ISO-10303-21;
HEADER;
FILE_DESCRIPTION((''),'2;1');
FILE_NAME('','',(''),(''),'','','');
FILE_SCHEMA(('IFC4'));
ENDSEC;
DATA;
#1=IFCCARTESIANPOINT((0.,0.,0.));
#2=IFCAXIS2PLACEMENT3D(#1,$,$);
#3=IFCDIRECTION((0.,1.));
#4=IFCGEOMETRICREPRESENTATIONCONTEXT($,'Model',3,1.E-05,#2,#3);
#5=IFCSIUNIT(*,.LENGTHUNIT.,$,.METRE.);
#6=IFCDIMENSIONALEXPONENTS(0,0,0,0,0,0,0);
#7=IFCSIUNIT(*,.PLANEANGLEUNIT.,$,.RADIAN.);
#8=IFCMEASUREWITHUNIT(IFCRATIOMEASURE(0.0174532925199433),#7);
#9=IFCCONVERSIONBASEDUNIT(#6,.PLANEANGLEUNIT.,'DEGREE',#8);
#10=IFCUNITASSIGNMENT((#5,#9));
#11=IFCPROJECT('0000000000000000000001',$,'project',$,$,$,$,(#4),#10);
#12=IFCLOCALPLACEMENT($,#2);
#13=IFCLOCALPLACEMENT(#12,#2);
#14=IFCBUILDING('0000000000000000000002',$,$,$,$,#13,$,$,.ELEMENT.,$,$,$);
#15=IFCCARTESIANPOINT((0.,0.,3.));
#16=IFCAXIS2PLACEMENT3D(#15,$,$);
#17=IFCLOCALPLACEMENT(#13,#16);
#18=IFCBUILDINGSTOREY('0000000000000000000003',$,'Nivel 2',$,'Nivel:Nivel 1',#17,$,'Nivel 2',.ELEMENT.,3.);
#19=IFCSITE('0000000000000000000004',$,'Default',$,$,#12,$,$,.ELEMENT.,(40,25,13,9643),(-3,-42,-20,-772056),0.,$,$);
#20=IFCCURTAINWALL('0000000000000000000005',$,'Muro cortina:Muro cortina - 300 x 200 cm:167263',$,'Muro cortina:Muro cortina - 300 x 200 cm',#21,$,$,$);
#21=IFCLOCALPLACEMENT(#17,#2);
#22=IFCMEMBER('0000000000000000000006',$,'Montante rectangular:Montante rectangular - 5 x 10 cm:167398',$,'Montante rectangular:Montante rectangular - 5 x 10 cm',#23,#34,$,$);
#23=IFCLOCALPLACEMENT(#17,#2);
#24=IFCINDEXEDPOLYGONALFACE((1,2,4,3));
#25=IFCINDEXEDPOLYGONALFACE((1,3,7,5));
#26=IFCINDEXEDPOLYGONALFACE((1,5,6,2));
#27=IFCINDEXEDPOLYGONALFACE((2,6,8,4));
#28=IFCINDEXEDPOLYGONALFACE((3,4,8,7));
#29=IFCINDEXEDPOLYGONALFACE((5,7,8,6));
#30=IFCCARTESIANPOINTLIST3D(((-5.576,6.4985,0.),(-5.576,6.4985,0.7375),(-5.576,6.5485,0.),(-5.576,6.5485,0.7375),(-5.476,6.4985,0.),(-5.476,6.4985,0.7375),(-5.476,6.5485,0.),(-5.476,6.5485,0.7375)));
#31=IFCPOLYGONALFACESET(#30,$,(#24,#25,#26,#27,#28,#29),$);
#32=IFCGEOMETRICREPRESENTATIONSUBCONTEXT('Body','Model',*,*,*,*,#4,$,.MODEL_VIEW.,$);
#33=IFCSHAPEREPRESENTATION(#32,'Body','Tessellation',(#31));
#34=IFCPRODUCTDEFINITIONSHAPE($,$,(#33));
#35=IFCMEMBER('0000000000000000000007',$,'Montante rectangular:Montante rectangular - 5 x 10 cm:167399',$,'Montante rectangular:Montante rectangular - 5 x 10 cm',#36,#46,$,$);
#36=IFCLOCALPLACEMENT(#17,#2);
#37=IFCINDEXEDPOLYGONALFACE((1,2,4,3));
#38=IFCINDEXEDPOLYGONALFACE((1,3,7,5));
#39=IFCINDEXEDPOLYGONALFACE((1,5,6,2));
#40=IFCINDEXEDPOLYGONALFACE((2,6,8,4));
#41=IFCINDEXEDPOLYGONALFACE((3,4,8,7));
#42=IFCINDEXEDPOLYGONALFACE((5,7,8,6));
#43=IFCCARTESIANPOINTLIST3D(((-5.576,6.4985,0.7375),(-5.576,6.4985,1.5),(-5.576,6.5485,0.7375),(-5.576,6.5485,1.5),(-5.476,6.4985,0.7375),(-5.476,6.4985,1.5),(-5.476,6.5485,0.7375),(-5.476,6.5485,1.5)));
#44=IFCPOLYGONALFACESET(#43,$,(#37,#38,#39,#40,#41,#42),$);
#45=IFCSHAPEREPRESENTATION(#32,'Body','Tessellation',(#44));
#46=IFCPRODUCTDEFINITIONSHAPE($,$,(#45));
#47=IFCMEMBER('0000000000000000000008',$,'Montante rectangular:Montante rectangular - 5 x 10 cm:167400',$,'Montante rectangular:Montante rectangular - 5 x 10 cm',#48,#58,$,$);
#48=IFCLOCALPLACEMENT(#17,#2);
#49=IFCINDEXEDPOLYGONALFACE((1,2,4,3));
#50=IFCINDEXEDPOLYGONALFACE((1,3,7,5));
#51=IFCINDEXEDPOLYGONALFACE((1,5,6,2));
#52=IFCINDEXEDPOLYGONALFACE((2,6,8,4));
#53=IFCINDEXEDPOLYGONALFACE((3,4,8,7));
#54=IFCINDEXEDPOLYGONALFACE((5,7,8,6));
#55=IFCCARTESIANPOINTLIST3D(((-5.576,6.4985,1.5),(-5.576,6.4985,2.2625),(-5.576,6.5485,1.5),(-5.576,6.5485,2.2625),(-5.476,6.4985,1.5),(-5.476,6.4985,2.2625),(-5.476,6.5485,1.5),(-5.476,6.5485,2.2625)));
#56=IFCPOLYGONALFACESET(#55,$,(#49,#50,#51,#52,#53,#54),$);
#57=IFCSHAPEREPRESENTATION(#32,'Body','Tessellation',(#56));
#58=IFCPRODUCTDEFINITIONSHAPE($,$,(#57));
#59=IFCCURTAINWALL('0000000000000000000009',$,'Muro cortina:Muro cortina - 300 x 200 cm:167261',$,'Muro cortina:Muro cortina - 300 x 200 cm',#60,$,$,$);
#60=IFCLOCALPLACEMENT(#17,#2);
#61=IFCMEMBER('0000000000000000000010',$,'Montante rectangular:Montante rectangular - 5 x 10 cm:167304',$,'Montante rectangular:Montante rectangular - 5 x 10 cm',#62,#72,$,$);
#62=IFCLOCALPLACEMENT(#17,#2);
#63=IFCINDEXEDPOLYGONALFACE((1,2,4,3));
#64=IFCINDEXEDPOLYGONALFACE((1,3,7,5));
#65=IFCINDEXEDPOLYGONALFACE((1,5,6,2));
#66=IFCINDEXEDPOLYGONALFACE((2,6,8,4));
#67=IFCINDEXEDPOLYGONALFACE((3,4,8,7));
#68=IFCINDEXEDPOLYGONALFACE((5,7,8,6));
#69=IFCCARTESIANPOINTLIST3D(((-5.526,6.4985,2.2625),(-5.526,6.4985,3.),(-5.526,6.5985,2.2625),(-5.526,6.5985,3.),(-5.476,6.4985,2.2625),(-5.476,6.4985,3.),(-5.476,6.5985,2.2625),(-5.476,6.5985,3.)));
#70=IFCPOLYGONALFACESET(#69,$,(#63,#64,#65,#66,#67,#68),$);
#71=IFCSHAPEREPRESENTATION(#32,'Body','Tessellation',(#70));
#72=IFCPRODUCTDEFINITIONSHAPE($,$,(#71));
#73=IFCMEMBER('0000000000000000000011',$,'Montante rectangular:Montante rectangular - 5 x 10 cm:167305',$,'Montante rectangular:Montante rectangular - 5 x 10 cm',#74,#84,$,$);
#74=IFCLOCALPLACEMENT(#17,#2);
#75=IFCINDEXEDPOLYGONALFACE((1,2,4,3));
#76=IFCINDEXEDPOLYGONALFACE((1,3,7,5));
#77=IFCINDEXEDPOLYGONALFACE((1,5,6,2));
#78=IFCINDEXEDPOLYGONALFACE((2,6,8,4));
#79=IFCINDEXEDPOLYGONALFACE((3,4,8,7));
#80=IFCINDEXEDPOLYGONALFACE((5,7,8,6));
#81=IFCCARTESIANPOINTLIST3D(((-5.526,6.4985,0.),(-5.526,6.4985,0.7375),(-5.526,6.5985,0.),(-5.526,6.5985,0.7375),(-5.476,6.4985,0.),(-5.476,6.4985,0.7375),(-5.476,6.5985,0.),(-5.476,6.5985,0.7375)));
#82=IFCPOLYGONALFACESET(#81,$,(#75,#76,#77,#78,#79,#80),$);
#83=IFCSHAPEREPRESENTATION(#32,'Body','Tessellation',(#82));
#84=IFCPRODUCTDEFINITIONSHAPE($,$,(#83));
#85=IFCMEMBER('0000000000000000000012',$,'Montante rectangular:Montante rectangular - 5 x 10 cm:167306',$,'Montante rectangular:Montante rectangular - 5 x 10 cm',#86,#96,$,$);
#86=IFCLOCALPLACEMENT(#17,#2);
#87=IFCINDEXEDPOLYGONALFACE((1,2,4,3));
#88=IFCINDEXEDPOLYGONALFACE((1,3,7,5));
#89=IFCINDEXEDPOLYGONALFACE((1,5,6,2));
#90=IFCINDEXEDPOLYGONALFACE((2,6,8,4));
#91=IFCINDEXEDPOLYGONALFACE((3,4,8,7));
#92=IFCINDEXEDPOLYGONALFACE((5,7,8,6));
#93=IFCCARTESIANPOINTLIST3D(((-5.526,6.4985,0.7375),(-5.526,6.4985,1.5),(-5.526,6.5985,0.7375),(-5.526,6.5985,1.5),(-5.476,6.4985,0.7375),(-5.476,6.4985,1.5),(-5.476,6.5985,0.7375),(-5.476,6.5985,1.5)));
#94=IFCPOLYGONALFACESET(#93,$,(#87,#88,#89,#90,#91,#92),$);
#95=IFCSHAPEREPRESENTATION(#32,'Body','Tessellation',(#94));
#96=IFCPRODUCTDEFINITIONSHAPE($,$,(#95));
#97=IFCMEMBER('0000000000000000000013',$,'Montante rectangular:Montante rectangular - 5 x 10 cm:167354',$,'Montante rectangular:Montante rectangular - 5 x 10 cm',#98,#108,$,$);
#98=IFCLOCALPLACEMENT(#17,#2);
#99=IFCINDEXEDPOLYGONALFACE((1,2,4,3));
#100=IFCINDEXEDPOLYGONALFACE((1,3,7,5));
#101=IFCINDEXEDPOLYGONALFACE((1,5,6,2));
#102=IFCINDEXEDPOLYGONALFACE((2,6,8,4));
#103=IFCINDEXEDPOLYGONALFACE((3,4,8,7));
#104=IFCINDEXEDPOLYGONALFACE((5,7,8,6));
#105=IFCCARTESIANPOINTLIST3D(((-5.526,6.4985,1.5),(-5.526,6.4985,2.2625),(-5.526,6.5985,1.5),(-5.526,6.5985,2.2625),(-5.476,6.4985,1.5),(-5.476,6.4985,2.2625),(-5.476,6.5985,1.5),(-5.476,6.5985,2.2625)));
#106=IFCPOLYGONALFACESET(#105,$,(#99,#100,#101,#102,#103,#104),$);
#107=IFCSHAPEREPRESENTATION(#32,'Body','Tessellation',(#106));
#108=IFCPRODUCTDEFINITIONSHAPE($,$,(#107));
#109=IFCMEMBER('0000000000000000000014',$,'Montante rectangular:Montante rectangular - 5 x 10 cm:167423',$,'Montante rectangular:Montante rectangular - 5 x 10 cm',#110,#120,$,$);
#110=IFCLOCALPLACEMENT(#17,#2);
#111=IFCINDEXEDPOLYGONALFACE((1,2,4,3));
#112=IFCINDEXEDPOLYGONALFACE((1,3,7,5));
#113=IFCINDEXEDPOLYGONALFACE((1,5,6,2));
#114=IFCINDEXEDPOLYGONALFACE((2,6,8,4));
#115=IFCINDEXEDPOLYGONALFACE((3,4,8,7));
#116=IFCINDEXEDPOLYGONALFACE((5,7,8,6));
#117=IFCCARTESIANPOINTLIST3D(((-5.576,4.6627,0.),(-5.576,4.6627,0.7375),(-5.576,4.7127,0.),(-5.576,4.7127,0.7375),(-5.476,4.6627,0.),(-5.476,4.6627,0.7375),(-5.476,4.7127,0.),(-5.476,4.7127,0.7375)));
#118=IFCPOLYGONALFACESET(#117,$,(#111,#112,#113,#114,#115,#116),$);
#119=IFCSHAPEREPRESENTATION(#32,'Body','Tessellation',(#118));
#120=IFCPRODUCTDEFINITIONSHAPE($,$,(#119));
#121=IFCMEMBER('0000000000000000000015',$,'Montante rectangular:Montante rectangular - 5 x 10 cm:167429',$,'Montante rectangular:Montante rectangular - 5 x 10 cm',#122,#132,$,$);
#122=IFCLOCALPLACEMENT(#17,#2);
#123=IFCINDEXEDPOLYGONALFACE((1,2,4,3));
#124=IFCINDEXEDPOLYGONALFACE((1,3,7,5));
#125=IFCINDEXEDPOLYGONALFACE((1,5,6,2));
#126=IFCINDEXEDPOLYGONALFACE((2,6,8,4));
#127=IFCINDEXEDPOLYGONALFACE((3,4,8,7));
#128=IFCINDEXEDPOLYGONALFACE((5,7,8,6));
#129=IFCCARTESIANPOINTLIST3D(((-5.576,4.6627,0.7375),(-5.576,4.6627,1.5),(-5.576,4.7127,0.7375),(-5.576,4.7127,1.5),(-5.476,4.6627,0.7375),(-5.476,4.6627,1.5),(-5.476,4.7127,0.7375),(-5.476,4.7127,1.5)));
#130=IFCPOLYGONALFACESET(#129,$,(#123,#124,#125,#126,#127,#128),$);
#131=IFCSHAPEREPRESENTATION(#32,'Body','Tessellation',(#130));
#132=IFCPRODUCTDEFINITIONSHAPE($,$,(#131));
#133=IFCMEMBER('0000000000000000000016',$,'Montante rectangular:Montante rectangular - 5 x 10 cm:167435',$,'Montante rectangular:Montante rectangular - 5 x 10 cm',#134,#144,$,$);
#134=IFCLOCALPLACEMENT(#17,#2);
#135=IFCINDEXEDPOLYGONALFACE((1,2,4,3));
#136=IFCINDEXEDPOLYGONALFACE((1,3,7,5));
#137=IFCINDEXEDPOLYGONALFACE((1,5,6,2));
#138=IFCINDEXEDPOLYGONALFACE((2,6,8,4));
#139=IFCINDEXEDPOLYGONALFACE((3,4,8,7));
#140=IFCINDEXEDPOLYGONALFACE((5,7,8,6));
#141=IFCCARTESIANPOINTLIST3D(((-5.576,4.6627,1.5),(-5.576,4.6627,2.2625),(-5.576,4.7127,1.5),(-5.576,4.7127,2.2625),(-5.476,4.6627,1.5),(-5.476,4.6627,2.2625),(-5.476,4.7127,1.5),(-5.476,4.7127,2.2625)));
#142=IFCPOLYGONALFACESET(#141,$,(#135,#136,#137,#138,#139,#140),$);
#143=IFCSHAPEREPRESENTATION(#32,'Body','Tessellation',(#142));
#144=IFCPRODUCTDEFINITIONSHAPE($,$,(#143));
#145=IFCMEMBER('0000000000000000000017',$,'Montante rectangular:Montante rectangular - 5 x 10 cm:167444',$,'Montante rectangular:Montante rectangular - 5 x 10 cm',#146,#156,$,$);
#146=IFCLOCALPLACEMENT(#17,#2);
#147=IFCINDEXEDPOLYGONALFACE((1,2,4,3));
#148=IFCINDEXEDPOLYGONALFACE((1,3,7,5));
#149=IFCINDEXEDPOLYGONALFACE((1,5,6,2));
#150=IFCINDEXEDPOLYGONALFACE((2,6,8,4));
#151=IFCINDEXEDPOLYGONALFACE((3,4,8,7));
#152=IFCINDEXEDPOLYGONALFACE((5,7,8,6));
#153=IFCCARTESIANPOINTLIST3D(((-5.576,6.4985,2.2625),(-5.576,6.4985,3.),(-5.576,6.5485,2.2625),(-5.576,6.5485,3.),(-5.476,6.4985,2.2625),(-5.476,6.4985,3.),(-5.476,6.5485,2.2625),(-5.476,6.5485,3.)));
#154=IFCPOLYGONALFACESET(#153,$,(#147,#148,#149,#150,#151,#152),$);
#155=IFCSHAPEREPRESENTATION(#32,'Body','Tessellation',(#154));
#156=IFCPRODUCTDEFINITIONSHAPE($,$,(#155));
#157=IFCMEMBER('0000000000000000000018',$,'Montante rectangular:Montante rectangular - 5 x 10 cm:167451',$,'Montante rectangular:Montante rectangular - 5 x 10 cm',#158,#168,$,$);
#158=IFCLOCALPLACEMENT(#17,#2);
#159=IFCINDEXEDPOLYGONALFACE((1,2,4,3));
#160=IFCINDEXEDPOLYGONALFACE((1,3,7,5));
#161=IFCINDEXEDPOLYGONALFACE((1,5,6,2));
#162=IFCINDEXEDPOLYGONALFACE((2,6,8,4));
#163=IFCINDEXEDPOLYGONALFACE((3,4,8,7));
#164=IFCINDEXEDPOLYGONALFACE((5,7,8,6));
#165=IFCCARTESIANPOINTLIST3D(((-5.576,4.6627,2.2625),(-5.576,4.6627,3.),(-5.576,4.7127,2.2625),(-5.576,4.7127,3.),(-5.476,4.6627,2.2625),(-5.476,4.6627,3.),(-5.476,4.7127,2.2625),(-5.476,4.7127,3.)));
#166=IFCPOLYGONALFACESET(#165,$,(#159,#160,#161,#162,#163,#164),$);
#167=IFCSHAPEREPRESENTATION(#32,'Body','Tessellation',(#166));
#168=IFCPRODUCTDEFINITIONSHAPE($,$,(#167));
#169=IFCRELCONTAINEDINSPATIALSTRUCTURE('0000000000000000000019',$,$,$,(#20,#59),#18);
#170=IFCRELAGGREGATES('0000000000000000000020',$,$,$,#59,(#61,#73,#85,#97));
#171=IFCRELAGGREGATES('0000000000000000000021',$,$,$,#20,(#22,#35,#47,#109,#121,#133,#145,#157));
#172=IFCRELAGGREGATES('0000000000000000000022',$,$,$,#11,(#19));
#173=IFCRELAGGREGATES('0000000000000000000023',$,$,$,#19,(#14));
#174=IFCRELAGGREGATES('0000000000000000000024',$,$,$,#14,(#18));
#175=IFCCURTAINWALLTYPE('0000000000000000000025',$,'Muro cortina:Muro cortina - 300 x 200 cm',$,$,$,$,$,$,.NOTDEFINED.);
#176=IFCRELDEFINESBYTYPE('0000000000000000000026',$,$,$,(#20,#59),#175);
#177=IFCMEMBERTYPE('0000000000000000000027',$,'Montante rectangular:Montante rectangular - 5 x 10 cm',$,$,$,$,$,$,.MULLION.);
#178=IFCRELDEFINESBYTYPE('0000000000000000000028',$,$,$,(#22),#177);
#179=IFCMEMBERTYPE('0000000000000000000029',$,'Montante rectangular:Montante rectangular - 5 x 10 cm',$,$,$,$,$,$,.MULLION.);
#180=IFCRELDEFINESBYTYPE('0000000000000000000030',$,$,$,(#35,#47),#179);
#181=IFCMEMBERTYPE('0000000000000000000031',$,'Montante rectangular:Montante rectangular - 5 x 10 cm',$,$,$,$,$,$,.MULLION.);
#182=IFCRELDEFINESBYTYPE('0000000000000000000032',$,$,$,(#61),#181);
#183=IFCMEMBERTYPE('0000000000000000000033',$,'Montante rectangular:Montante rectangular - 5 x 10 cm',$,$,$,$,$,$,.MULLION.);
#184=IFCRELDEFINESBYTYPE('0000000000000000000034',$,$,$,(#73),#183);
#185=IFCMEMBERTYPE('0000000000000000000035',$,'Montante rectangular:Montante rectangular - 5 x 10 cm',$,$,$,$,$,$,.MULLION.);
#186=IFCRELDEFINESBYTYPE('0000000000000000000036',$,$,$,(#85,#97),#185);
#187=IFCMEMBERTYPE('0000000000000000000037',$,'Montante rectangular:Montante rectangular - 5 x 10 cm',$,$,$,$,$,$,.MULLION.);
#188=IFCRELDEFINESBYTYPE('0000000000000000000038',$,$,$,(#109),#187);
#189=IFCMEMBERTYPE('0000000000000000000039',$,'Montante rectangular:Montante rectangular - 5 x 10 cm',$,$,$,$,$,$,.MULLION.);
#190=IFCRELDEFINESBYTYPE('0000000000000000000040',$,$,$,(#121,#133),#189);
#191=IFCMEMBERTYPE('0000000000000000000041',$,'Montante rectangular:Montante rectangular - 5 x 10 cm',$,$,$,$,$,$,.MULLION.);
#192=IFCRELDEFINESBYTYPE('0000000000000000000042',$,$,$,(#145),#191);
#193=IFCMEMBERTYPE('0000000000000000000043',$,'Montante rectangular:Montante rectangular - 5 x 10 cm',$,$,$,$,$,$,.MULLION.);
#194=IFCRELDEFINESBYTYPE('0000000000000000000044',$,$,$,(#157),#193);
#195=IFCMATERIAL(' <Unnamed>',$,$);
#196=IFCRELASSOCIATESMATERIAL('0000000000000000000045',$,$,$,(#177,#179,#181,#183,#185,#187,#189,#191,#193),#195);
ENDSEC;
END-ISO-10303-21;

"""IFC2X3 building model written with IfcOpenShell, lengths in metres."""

from ifc_helpers import new_model, entity, si_unit, converted_unit, direction, frame, origin, origin_2d_with_axis, place, context, subcontext, project, spatial, rectangle, extrude, source, transform, mapped, material, type_object, type_shapes, element, aggregate, save


model = new_model("IFC2X3")

# Units and contexts
model_context = context("Model", 3, precision=1e-05, world=origin(), true_north=direction((0.0, 1.0)))
body_context = subcontext(model_context, "Body", "Model", "MODEL_VIEW")
ifc_project = project(units=[si_unit("LENGTHUNIT", "METRE"), converted_unit("PLANEANGLEUNIT", "DEGREE", entity("IfcRatioMeasure", 0.0174532925199433), si_unit("PLANEANGLEUNIT", "RADIAN"), dimensions=[0, 0, 0, 0, 0, 0, 0])], contexts=[model_context])

# Site, building, storey
site_placement = place(None, origin())
site = spatial("IfcSite", under=ifc_project, at=site_placement, Name="Default", CompositionType="ELEMENT", RefLatitude=(40, 25, 13, 9643), RefLongitude=(-3, -42, -20, -772056), RefElevation=0.0)
building_placement = place(site_placement, origin())
building = spatial("IfcBuilding", under=site, at=building_placement, CompositionType="ELEMENT")
storey_placement = place(building_placement, frame((0.0, 0.0, 3.0)))
storey = spatial("IfcBuildingStorey", under=building, at=storey_placement, Name="Nivel 2", ObjectType="Nivel:Nivel 1", LongName="Nivel 2", CompositionType="ELEMENT", Elevation=3.0)

# Curtain walls, members
curtain_wall_type = type_object("IfcCurtainWallType", Name="Muro cortina:Muro cortina - 300 x 200 cm", PredefinedType="NOTDEFINED")
curtain_wall_1_placement = place(storey_placement, frame((0.0, 0.0, -3.0)))
curtain_wall_1 = element("IfcCurtainWall", 1, at=curtain_wall_1_placement, inside=storey, type_object=curtain_wall_type, Name="Muro cortina:Muro cortina - 300 x 200 cm:167263", ObjectType="Muro cortina:Muro cortina - 300 x 200 cm")
ifc_material_1 = material(Name=" <Unnamed>")
member_type_1 = type_object("IfcMemberType", Name="Montante rectangular:Montante rectangular - 5 x 10 cm", PredefinedType="MULLION", material=ifc_material_1)
shared_shape_1 = source(origin(), body_context, "Body", "SweptSolid", [
    extrude(rectangle(XDim=0.1, YDim=0.05, at=origin_2d_with_axis()), frame((-0.025, 0.0, -0.7375), z_axis=(0.0, 0.0, 1.0), x_axis=(0.0, -1.0, 0.0)), (0.0, 0.0, 1.0), 0.7375),
])
type_shapes(member_type_1, [shared_shape_1])
member_1_placement = place(storey_placement, frame((-5.526, 6.5485, 0.0), z_axis=(0.0, 0.0, -1.0), x_axis=(0.0, 1.0, 0.0)))
member_1 = element("IfcMember", 2, at=member_1_placement, type_object=member_type_1, Name="Montante rectangular:Montante rectangular - 5 x 10 cm:167398", ObjectType="Montante rectangular:Montante rectangular - 5 x 10 cm", context=body_context, shape_type="MappedRepresentation", body=[
    mapped(shared_shape_1, transform((0.0, 0.0, 0.0), scale=1.0)),
])
member_type_2 = type_object("IfcMemberType", Name="Montante rectangular:Montante rectangular - 5 x 10 cm", PredefinedType="MULLION", material=ifc_material_1)
shared_shape_2 = source(origin(), body_context, "Body", "SweptSolid", [
    extrude(rectangle(XDim=0.1, YDim=0.05, at=origin_2d_with_axis()), frame((-0.025, 0.0, -0.7625), z_axis=(0.0, 0.0, 1.0), x_axis=(0.0, -1.0, 0.0)), (0.0, 0.0, 1.0), 0.7625),
])
type_shapes(member_type_2, [shared_shape_2])
member_2_placement = place(storey_placement, frame((-5.526, 6.5485, 0.7375), z_axis=(0.0, 0.0, -1.0), x_axis=(0.0, 1.0, 0.0)))
member_2 = element("IfcMember", 3, at=member_2_placement, type_object=member_type_2, Name="Montante rectangular:Montante rectangular - 5 x 10 cm:167399", ObjectType="Montante rectangular:Montante rectangular - 5 x 10 cm", context=body_context, shape_type="MappedRepresentation", body=[
    mapped(shared_shape_2, transform((0.0, 0.0, 0.0), scale=1.0)),
])
member_3_placement = place(storey_placement, frame((-5.526, 6.5485, 1.5), z_axis=(0.0, 0.0, -1.0), x_axis=(0.0, 1.0, 0.0)))
member_3 = element("IfcMember", 4, at=member_3_placement, type_object=member_type_2, Name="Montante rectangular:Montante rectangular - 5 x 10 cm:167400", ObjectType="Montante rectangular:Montante rectangular - 5 x 10 cm", context=body_context, shape_type="MappedRepresentation", body=[
    mapped(shared_shape_2, transform((0.0, 0.0, 0.0), scale=1.0)),
])
curtain_wall_2_placement = place(storey_placement, frame((0.0, 0.0, -3.0)))
curtain_wall_2 = element("IfcCurtainWall", 5, at=curtain_wall_2_placement, inside=storey, type_object=curtain_wall_type, Name="Muro cortina:Muro cortina - 300 x 200 cm:167261", ObjectType="Muro cortina:Muro cortina - 300 x 200 cm")
member_type_3 = type_object("IfcMemberType", Name="Montante rectangular:Montante rectangular - 5 x 10 cm", PredefinedType="MULLION", material=ifc_material_1)
shared_shape_3 = source(origin(), body_context, "Body", "SweptSolid", [
    extrude(rectangle(XDim=0.1, YDim=0.05, at=origin_2d_with_axis()), frame((-0.025, 0.0, -0.7375), z_axis=(0.0, 0.0, 1.0), x_axis=(0.0, -1.0, 0.0)), (0.0, 0.0, 1.0), 0.7375),
])
type_shapes(member_type_3, [shared_shape_3])
member_4_placement = place(storey_placement, frame((-5.526, 6.5485, 3.0), z_axis=(0.0, 0.0, 1.0), x_axis=(-1.0, 0.0, 0.0)))
member_4 = element("IfcMember", 6, at=member_4_placement, type_object=member_type_3, Name="Montante rectangular:Montante rectangular - 5 x 10 cm:167304", ObjectType="Montante rectangular:Montante rectangular - 5 x 10 cm", context=body_context, shape_type="MappedRepresentation", body=[
    mapped(shared_shape_3, transform((0.0, 0.0, 0.0), scale=1.0)),
])
member_type_4 = type_object("IfcMemberType", Name="Montante rectangular:Montante rectangular - 5 x 10 cm", PredefinedType="MULLION", material=ifc_material_1)
shared_shape_4 = source(origin(), body_context, "Body", "SweptSolid", [
    extrude(rectangle(XDim=0.1, YDim=0.05, at=origin_2d_with_axis()), frame((-0.025, 0.0, -0.7375), z_axis=(0.0, 0.0, 1.0), x_axis=(0.0, -1.0, 0.0)), (0.0, 0.0, 1.0), 0.7375),
])
type_shapes(member_type_4, [shared_shape_4])
member_5_placement = place(storey_placement, frame((-5.526, 6.5485, 0.7375), z_axis=(0.0, 0.0, 1.0), x_axis=(-1.0, 0.0, 0.0)))
member_5 = element("IfcMember", 7, at=member_5_placement, type_object=member_type_4, Name="Montante rectangular:Montante rectangular - 5 x 10 cm:167305", ObjectType="Montante rectangular:Montante rectangular - 5 x 10 cm", context=body_context, shape_type="MappedRepresentation", body=[
    mapped(shared_shape_4, transform((0.0, 0.0, 0.0), scale=1.0)),
])
member_type_5 = type_object("IfcMemberType", Name="Montante rectangular:Montante rectangular - 5 x 10 cm", PredefinedType="MULLION", material=ifc_material_1)
shared_shape_5 = source(origin(), body_context, "Body", "SweptSolid", [
    extrude(rectangle(XDim=0.1, YDim=0.05, at=origin_2d_with_axis()), frame((-0.025, 0.0, -0.7625), z_axis=(0.0, 0.0, 1.0), x_axis=(0.0, -1.0, 0.0)), (0.0, 0.0, 1.0), 0.7625),
])
type_shapes(member_type_5, [shared_shape_5])
member_6_placement = place(storey_placement, frame((-5.526, 6.5485, 1.5), z_axis=(0.0, 0.0, 1.0), x_axis=(-1.0, 0.0, 0.0)))
member_6 = element("IfcMember", 8, at=member_6_placement, type_object=member_type_5, Name="Montante rectangular:Montante rectangular - 5 x 10 cm:167306", ObjectType="Montante rectangular:Montante rectangular - 5 x 10 cm", context=body_context, shape_type="MappedRepresentation", body=[
    mapped(shared_shape_5, transform((0.0, 0.0, 0.0), scale=1.0)),
])
member_7_placement = place(storey_placement, frame((-5.526, 6.5485, 2.2625), z_axis=(0.0, 0.0, 1.0), x_axis=(-1.0, 0.0, 0.0)))
member_7 = element("IfcMember", 9, at=member_7_placement, type_object=member_type_5, Name="Montante rectangular:Montante rectangular - 5 x 10 cm:167354", ObjectType="Montante rectangular:Montante rectangular - 5 x 10 cm", context=body_context, shape_type="MappedRepresentation", body=[
    mapped(shared_shape_5, transform((0.0, 0.0, 0.0), scale=1.0)),
])

# Members
member_type_6 = type_object("IfcMemberType", Name="Montante rectangular:Montante rectangular - 5 x 10 cm", PredefinedType="MULLION", material=ifc_material_1)
shared_shape_6 = source(origin(), body_context, "Body", "SweptSolid", [
    extrude(rectangle(XDim=0.1, YDim=0.05, at=origin_2d_with_axis()), frame((0.0, 0.0, -0.7375), z_axis=(0.0, 0.0, 1.0), x_axis=(0.0, -1.0, 0.0)), (0.0, 0.0, 1.0), 0.7375),
])
type_shapes(member_type_6, [shared_shape_6])
member_8_placement = place(storey_placement, frame((-5.526, 4.6877, 0.0), z_axis=(0.0, 0.0, -1.0), x_axis=(0.0, 1.0, 0.0)))
member_8 = element("IfcMember", 10, at=member_8_placement, type_object=member_type_6, Name="Montante rectangular:Montante rectangular - 5 x 10 cm:167423", ObjectType="Montante rectangular:Montante rectangular - 5 x 10 cm", context=body_context, shape_type="MappedRepresentation", body=[
    mapped(shared_shape_6, transform((0.0, 0.0, 0.0), scale=1.0)),
])
member_type_7 = type_object("IfcMemberType", Name="Montante rectangular:Montante rectangular - 5 x 10 cm", PredefinedType="MULLION", material=ifc_material_1)
shared_shape_7 = source(origin(), body_context, "Body", "SweptSolid", [
    extrude(rectangle(XDim=0.1, YDim=0.05, at=origin_2d_with_axis()), frame((0.0, 0.0, -0.7625), z_axis=(0.0, 0.0, 1.0), x_axis=(0.0, -1.0, 0.0)), (0.0, 0.0, 1.0), 0.7625),
])
type_shapes(member_type_7, [shared_shape_7])
member_9_placement = place(storey_placement, frame((-5.526, 4.6877, 0.7375), z_axis=(0.0, 0.0, -1.0), x_axis=(0.0, 1.0, 0.0)))
member_9 = element("IfcMember", 11, at=member_9_placement, type_object=member_type_7, Name="Montante rectangular:Montante rectangular - 5 x 10 cm:167429", ObjectType="Montante rectangular:Montante rectangular - 5 x 10 cm", context=body_context, shape_type="MappedRepresentation", body=[
    mapped(shared_shape_7, transform((0.0, 0.0, 0.0), scale=1.0)),
])
member_10_placement = place(storey_placement, frame((-5.526, 4.6877, 1.5), z_axis=(0.0, 0.0, -1.0), x_axis=(0.0, 1.0, 0.0)))
member_10 = element("IfcMember", 12, at=member_10_placement, type_object=member_type_7, Name="Montante rectangular:Montante rectangular - 5 x 10 cm:167435", ObjectType="Montante rectangular:Montante rectangular - 5 x 10 cm", context=body_context, shape_type="MappedRepresentation", body=[
    mapped(shared_shape_7, transform((0.0, 0.0, 0.0), scale=1.0)),
])
member_type_8 = type_object("IfcMemberType", Name="Montante rectangular:Montante rectangular - 5 x 10 cm", PredefinedType="MULLION", material=ifc_material_1)
shared_shape_8 = source(origin(), body_context, "Body", "SweptSolid", [
    extrude(rectangle(XDim=0.1, YDim=0.05, at=origin_2d_with_axis()), frame((-0.025, 0.0, -0.7375), z_axis=(0.0, 0.0, 1.0), x_axis=(0.0, -1.0, 0.0)), (0.0, 0.0, 1.0), 0.7375),
])
type_shapes(member_type_8, [shared_shape_8])
member_11_placement = place(storey_placement, frame((-5.526, 6.5485, 2.2625), z_axis=(0.0, 0.0, -1.0), x_axis=(0.0, 1.0, 0.0)))
member_11 = element("IfcMember", 13, at=member_11_placement, type_object=member_type_8, Name="Montante rectangular:Montante rectangular - 5 x 10 cm:167444", ObjectType="Montante rectangular:Montante rectangular - 5 x 10 cm", context=body_context, shape_type="MappedRepresentation", body=[
    mapped(shared_shape_8, transform((0.0, 0.0, 0.0), scale=1.0)),
])
member_type_9 = type_object("IfcMemberType", Name="Montante rectangular:Montante rectangular - 5 x 10 cm", PredefinedType="MULLION", material=ifc_material_1)
shared_shape_9 = source(origin(), body_context, "Body", "SweptSolid", [
    extrude(rectangle(XDim=0.1, YDim=0.05, at=origin_2d_with_axis()), frame((0.0, 0.0, -0.7375), z_axis=(0.0, 0.0, 1.0), x_axis=(0.0, -1.0, 0.0)), (0.0, 0.0, 1.0), 0.7375),
])
type_shapes(member_type_9, [shared_shape_9])
member_12_placement = place(storey_placement, frame((-5.526, 4.6877, 2.2625), z_axis=(0.0, 0.0, -1.0), x_axis=(0.0, 1.0, 0.0)))
member_12 = element("IfcMember", 14, at=member_12_placement, type_object=member_type_9, Name="Montante rectangular:Montante rectangular - 5 x 10 cm:167451", ObjectType="Montante rectangular:Montante rectangular - 5 x 10 cm", context=body_context, shape_type="MappedRepresentation", body=[
    mapped(shared_shape_9, transform((0.0, 0.0, 0.0), scale=1.0)),
])

aggregate(curtain_wall_2, [member_4, member_5, member_6, member_7])
aggregate(curtain_wall_1, [member_1, member_2, member_3, member_8, member_9, member_10, member_11, member_12])

save(model, "model.ifc")
